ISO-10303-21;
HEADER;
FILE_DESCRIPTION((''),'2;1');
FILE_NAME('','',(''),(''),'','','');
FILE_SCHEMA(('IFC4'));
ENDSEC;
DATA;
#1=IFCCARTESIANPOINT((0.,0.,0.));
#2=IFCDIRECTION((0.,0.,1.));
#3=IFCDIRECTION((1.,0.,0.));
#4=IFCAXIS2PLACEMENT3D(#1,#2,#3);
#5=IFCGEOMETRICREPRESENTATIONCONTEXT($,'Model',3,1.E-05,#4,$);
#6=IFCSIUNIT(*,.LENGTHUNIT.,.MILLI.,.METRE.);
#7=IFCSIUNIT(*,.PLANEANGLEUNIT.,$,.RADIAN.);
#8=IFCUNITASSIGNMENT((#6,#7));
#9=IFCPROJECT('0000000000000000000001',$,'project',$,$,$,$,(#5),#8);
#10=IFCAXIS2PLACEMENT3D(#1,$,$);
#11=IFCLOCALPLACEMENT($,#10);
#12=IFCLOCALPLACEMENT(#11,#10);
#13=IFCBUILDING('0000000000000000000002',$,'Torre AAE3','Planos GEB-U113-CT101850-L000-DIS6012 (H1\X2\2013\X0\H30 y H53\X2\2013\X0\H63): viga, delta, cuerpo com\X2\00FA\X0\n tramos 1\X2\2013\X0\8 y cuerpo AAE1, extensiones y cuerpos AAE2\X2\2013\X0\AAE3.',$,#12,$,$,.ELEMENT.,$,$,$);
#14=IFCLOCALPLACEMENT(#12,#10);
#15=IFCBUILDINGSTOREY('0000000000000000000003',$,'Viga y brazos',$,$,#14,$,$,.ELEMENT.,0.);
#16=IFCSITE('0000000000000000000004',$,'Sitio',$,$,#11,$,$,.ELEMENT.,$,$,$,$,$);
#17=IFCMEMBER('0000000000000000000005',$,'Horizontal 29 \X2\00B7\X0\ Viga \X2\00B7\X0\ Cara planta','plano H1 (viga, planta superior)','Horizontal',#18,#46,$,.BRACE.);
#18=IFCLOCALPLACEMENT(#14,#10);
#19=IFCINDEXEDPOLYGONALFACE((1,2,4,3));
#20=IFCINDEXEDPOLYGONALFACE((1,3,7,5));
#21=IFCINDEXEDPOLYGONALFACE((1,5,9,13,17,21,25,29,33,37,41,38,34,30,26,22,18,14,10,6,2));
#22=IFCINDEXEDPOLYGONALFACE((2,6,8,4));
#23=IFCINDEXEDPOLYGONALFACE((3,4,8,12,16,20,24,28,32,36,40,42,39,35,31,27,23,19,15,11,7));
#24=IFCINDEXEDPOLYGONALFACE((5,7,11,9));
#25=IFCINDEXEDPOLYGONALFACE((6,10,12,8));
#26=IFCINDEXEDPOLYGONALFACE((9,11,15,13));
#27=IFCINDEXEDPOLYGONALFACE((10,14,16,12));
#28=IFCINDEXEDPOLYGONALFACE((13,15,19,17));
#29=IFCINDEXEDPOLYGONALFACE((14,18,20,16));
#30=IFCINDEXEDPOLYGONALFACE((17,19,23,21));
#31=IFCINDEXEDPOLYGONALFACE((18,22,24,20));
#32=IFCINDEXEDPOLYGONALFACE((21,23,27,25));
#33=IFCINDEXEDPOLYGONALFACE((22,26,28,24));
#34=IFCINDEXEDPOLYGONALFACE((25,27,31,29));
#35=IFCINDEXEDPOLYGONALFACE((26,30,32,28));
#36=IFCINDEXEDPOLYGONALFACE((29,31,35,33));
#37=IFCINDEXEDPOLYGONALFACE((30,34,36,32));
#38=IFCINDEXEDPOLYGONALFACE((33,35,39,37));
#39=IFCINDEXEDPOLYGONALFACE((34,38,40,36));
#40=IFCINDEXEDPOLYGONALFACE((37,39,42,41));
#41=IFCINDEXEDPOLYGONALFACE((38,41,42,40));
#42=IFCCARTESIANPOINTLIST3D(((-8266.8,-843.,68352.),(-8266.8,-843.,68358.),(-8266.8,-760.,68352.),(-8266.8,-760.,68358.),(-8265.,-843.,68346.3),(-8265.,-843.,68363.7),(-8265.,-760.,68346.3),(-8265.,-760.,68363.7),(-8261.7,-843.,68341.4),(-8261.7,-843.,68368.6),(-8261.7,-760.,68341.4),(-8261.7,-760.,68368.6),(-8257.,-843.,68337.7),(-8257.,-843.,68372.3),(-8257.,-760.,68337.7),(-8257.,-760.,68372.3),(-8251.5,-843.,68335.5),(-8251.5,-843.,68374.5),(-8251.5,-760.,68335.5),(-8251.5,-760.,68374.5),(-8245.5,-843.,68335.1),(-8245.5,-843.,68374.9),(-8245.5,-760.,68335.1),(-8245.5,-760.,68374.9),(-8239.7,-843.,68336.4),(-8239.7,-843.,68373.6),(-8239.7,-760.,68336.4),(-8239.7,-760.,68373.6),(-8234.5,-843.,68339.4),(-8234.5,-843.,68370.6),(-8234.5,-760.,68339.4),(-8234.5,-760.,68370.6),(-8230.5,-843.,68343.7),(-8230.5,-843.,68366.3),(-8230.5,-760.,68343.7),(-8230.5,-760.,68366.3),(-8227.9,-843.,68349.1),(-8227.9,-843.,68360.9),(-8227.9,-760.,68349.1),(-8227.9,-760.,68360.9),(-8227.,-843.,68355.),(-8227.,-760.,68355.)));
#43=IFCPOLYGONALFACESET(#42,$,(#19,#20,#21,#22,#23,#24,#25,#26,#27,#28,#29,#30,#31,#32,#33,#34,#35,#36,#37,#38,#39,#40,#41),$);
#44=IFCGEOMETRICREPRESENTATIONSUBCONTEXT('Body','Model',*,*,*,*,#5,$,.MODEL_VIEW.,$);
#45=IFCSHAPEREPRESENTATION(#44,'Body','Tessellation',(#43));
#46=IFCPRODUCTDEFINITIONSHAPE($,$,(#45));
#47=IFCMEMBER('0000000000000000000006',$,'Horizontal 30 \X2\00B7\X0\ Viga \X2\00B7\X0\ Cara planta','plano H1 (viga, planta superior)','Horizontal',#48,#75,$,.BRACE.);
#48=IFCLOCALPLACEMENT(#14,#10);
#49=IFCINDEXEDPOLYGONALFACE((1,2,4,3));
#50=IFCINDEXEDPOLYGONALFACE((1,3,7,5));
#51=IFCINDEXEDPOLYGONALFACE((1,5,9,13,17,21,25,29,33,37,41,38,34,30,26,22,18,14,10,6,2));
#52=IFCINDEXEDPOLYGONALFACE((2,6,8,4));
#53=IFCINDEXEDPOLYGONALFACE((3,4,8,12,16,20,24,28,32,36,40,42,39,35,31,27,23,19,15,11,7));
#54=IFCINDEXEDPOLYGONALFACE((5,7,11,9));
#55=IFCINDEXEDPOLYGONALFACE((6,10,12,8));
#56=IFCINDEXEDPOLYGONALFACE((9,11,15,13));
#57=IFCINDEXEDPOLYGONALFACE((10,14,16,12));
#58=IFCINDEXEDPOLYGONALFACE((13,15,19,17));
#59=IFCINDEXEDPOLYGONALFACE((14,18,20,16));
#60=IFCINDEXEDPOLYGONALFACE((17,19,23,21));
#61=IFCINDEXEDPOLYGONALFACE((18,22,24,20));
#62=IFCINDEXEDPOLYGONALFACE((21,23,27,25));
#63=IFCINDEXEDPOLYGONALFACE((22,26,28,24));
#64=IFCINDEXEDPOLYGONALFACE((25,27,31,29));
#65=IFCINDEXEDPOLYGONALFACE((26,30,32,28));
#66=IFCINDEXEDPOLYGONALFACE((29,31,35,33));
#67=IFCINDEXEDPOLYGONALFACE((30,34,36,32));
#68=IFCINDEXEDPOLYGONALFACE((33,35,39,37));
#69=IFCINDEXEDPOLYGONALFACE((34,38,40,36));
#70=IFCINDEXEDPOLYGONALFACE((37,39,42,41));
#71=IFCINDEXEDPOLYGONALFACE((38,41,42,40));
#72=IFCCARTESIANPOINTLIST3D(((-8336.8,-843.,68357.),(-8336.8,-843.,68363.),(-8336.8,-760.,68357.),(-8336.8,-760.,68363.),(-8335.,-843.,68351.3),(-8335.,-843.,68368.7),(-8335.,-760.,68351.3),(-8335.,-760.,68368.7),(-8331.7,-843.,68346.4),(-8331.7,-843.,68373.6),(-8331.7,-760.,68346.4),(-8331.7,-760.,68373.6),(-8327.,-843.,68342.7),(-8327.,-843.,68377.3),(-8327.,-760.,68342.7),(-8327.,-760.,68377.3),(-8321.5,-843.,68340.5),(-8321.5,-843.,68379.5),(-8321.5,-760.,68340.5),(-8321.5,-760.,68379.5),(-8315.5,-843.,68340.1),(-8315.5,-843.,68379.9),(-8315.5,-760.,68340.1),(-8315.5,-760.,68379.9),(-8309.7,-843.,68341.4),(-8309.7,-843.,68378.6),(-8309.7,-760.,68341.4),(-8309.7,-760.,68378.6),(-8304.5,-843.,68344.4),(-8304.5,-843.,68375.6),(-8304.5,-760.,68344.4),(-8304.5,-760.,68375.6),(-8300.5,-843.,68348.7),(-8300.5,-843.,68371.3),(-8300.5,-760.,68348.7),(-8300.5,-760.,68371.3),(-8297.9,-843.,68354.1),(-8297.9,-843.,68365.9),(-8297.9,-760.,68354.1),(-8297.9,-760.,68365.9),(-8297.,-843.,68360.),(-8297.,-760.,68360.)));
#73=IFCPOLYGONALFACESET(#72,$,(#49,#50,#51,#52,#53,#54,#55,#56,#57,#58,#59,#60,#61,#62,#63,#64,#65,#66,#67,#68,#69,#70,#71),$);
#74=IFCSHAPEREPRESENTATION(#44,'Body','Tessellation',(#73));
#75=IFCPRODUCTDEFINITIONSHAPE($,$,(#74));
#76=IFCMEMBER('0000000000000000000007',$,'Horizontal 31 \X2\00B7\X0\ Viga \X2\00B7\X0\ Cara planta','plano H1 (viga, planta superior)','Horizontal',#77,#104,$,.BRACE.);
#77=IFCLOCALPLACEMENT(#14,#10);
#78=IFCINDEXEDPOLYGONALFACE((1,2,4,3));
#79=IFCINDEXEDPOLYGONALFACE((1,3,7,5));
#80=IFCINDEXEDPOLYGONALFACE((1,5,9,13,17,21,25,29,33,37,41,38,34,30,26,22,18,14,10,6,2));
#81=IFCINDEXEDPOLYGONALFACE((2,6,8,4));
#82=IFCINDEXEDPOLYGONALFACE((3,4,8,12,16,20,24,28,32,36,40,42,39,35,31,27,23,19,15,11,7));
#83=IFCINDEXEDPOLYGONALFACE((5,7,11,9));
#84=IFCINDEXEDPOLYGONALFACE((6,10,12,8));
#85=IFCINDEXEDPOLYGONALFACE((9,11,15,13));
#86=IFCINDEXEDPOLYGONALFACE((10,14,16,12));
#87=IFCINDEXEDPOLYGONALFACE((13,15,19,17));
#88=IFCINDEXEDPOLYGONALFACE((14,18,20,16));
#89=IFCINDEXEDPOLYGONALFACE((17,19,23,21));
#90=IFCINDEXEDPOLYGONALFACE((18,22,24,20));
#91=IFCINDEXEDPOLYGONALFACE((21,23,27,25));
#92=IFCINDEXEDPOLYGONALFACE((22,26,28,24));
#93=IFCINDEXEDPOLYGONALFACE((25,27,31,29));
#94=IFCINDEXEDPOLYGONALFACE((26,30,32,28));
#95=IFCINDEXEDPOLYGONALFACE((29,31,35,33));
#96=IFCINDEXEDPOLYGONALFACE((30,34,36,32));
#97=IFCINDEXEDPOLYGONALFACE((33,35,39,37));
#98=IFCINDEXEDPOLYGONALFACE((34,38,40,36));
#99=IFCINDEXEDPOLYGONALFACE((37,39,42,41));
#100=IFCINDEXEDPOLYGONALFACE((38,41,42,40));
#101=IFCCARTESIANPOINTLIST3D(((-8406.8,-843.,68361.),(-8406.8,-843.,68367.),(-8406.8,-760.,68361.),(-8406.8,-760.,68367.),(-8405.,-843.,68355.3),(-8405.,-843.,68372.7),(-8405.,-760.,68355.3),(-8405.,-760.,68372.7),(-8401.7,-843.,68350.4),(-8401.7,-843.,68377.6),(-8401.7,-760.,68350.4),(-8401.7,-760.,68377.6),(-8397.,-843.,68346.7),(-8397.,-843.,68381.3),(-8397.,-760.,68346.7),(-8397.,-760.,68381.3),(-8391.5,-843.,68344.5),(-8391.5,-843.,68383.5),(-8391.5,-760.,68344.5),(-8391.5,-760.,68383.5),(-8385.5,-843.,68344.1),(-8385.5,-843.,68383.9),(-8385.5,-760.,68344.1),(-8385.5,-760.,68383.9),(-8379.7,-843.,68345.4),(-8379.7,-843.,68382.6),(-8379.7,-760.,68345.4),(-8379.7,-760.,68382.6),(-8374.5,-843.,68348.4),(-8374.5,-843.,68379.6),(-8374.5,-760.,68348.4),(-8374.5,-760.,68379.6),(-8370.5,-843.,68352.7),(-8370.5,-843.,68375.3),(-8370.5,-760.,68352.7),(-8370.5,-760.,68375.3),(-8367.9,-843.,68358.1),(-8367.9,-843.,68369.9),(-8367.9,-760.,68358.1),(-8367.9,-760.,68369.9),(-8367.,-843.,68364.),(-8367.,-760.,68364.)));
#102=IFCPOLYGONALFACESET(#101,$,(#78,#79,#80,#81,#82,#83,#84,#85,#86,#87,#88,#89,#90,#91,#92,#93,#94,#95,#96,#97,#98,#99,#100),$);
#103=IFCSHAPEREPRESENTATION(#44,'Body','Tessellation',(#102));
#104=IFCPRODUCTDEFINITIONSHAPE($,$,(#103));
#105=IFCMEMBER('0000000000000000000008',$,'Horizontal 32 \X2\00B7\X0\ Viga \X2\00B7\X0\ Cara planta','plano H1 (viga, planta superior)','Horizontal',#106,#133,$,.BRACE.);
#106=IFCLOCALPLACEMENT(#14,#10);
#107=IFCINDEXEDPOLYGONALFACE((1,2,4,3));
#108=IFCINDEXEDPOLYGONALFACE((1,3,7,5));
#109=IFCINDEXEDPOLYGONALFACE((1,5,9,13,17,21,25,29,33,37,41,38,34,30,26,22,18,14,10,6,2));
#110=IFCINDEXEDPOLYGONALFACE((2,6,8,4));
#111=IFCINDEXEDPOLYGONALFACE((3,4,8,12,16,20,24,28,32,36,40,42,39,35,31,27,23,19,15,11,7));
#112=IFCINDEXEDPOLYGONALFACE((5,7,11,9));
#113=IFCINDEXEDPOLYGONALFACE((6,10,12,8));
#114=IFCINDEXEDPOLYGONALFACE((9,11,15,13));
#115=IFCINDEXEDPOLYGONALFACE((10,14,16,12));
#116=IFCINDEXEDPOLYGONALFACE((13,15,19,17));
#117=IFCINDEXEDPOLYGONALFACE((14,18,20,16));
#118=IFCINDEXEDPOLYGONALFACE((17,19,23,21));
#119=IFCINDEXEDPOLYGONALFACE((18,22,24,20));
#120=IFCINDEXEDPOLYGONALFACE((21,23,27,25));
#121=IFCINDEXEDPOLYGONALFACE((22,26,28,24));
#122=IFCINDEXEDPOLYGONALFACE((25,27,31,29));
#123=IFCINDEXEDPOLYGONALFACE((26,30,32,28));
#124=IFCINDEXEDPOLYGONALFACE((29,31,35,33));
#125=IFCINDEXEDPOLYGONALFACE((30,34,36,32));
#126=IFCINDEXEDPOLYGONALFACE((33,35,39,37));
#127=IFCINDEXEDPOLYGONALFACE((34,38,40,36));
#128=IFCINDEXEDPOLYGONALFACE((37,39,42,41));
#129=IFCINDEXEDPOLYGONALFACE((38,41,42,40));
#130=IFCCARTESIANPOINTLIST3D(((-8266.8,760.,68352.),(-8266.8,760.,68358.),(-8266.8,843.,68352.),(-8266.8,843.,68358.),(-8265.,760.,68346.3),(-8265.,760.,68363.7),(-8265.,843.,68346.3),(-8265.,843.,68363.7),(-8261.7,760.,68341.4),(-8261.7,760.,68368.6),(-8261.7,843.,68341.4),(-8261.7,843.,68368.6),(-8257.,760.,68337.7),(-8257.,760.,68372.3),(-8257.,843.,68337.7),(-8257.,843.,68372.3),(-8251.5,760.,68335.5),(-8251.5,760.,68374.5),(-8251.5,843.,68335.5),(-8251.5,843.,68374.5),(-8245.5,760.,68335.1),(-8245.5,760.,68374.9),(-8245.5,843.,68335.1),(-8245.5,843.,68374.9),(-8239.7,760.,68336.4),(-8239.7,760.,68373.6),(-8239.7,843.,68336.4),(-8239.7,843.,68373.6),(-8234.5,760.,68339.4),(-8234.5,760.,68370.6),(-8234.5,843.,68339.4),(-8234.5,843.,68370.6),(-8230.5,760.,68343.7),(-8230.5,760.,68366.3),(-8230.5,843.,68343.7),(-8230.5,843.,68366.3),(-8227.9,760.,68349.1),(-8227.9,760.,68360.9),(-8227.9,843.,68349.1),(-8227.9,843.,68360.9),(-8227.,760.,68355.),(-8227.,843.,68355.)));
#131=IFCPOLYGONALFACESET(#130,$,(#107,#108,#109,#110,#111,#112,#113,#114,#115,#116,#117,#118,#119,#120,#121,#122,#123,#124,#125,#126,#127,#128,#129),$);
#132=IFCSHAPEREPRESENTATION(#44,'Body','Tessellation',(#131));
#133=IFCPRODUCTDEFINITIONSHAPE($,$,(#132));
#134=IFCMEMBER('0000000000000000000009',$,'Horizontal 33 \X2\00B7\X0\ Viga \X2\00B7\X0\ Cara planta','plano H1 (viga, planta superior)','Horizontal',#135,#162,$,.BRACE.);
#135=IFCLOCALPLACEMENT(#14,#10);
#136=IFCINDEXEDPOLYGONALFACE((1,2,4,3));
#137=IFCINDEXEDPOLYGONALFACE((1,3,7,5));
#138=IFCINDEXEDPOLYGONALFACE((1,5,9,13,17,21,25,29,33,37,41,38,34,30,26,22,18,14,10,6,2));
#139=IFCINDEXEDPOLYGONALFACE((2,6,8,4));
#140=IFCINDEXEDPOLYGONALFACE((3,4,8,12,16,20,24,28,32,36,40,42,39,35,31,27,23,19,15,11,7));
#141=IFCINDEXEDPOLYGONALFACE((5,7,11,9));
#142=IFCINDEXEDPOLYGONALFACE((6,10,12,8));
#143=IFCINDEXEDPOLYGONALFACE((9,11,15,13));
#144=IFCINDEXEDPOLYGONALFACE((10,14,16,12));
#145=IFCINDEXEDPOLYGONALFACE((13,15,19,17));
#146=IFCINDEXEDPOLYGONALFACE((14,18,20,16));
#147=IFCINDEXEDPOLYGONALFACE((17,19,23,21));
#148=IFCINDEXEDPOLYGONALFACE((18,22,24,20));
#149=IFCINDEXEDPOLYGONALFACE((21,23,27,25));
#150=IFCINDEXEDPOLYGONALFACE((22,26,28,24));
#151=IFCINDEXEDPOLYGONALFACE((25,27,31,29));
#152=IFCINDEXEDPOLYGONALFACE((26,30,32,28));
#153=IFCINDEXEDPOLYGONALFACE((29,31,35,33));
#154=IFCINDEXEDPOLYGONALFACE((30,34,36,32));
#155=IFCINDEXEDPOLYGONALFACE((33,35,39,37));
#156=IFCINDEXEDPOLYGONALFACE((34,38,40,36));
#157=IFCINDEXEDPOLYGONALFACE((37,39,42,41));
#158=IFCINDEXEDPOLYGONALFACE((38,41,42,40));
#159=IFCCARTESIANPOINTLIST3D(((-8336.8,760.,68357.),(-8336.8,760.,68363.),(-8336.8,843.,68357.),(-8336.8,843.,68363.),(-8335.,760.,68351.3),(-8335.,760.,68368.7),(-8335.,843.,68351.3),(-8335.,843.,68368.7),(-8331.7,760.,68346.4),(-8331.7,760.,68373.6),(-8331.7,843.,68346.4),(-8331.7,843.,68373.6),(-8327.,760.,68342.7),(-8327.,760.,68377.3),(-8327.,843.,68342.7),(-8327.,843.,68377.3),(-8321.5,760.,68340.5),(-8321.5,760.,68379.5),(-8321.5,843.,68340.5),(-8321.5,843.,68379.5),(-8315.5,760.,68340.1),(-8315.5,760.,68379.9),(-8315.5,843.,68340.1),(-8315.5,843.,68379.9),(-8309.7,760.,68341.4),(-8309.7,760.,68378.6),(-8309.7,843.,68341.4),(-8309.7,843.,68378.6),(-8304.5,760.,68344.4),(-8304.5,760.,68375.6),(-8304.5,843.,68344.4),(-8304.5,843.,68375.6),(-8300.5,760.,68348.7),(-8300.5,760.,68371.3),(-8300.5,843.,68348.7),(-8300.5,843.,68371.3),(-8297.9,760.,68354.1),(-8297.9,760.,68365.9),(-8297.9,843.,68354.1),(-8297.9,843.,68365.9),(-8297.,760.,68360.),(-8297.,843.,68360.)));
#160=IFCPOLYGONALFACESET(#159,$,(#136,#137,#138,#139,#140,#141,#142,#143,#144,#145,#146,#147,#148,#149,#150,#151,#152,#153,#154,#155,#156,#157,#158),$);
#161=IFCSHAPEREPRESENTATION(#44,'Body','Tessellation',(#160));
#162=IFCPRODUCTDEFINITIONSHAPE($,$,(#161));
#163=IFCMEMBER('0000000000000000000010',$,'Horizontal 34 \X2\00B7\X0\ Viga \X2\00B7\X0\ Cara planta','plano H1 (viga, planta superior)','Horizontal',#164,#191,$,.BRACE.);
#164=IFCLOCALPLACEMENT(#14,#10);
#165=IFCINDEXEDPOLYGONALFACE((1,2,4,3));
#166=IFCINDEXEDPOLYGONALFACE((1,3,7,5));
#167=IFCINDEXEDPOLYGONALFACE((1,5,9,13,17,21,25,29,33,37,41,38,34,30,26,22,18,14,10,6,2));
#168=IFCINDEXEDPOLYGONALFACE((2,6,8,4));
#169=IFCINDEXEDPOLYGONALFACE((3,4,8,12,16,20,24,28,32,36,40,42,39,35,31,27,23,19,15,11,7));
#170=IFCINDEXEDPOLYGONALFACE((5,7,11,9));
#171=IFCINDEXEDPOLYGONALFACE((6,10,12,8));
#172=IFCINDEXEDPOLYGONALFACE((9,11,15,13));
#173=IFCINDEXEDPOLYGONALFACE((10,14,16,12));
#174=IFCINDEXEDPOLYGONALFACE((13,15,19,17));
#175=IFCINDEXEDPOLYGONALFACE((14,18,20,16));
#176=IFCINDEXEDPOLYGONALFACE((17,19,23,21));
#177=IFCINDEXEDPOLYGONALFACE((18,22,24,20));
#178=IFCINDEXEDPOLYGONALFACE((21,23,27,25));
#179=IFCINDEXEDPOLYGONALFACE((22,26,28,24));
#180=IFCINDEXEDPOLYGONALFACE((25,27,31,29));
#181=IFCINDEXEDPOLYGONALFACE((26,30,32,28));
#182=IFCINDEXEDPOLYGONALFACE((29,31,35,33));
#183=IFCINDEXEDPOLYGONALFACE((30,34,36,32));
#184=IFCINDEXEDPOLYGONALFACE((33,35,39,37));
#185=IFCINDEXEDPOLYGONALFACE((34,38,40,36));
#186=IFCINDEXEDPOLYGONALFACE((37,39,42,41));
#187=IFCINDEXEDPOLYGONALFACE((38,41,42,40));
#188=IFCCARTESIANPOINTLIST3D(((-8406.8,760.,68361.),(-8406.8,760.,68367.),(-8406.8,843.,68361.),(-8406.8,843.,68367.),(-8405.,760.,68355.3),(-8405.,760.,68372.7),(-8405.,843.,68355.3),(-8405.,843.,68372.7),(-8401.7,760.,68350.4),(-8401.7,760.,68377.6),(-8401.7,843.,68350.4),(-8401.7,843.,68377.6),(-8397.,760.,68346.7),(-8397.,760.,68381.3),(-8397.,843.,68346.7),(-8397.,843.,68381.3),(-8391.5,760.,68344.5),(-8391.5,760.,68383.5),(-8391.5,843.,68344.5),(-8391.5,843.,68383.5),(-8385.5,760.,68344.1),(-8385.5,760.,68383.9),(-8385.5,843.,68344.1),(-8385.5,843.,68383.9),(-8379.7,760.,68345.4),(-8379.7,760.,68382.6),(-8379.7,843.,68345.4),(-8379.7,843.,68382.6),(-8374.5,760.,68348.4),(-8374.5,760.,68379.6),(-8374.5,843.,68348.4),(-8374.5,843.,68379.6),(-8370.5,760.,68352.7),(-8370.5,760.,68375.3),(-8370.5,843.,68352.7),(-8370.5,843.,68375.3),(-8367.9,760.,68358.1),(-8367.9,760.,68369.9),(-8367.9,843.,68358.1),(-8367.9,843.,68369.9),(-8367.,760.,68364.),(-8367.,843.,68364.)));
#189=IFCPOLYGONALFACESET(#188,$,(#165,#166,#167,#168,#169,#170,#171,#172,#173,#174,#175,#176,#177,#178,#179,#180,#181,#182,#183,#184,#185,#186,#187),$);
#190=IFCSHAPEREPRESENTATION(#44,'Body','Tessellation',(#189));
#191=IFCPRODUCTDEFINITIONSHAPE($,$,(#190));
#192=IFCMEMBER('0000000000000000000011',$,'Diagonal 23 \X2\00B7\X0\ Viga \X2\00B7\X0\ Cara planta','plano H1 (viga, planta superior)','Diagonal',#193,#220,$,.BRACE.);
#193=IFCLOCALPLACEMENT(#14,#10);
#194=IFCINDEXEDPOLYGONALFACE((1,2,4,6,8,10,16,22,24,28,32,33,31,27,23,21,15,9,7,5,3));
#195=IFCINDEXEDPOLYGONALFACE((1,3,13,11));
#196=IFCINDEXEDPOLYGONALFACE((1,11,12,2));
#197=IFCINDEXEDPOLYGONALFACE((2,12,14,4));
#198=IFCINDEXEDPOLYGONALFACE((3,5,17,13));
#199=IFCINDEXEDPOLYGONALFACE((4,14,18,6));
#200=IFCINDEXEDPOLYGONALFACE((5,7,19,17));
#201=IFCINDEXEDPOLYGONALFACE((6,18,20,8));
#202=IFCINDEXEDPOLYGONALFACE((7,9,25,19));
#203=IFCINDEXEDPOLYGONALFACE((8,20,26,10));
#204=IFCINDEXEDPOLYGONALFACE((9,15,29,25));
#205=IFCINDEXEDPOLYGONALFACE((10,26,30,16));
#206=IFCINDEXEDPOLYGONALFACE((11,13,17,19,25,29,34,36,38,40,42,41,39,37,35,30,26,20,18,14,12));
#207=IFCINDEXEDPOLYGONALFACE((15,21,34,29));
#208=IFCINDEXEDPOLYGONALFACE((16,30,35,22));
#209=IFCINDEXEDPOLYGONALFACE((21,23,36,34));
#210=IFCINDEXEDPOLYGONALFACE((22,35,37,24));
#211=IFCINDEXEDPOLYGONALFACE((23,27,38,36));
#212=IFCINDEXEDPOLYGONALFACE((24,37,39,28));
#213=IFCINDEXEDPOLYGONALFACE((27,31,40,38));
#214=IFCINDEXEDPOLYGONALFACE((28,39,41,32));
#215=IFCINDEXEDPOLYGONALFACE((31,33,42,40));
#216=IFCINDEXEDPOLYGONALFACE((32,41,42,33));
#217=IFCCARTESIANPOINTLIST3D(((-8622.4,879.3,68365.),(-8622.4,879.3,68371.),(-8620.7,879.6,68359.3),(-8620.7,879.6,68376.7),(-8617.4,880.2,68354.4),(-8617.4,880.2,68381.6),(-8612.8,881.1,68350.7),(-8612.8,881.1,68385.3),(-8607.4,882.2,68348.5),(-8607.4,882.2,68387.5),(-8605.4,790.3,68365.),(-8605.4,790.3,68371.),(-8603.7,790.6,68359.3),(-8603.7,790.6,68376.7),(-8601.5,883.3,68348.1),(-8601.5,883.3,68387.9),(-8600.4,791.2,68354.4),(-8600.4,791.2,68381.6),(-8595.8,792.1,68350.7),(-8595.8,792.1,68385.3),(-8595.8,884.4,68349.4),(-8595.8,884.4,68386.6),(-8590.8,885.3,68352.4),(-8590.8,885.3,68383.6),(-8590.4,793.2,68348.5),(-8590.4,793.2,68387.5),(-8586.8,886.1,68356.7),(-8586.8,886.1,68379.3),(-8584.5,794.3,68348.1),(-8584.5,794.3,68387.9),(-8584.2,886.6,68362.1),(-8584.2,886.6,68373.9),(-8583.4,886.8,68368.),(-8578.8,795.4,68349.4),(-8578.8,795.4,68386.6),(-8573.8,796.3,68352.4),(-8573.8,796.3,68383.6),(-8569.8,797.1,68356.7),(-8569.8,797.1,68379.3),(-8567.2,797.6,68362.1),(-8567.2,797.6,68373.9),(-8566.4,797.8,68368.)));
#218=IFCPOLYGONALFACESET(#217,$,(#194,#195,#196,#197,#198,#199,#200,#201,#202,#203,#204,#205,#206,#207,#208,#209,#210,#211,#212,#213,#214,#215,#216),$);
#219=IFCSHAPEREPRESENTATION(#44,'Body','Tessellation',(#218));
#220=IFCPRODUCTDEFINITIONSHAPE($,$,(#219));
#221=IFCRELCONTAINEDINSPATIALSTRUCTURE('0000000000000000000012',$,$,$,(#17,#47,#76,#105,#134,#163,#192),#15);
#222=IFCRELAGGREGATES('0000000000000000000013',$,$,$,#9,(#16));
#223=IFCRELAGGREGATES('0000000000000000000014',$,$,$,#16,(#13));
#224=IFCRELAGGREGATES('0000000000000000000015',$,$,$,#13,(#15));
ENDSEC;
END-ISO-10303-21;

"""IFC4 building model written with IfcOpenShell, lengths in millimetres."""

from ifc_helpers import new_model, si_unit, frame, origin, origin_with_axes, place, context, subcontext, project, spatial, circle, extrude, element, save


model = new_model("IFC4")

# Units and contexts
model_context = context("Model", 3, precision=1e-05, world=origin_with_axes())
body_context = subcontext(model_context, "Body", "Model", "MODEL_VIEW")
ifc_project = project(units=[si_unit("LENGTHUNIT", "METRE", prefix="MILLI"), si_unit("PLANEANGLEUNIT", "RADIAN")], contexts=[model_context])

# Site, building, storey
site_placement = place(None, origin())
site = spatial("IfcSite", under=ifc_project, at=site_placement, Name="Sitio", CompositionType="ELEMENT")
building_placement = place(site_placement, origin())
building = spatial("IfcBuilding", under=site, at=building_placement, Name="Torre AAE3", Description="Planos GEB-U113-CT101850-L000-DIS6012 (H1–H30 y H53–H63): viga, delta, cuerpo común tramos 1–8 y cuerpo AAE1, extensiones y cuerpos AAE2–AAE3.", CompositionType="ELEMENT")
storey_placement = place(building_placement, origin())
storey = spatial("IfcBuildingStorey", under=building, at=storey_placement, Name="Viga y brazos", CompositionType="ELEMENT", Elevation=0.0)

# Members
for number, where, z_axis, x_axis, name in (
    (1, (-8247.0, -843.0, 68355.0), (0.0, 1.0, 0.0), (1.0, 0.0, 0.0), "Horizontal 29 · Viga · Cara planta"),
    (2, (-8317.0, -843.0, 68360.0), (0.0, 1.0, 0.0), (1.0, 0.0, 0.0), "Horizontal 30 · Viga · Cara planta"),
    (3, (-8387.0, -843.0, 68364.0), (0.0, 1.0, 0.0), (1.0, 0.0, 0.0), "Horizontal 31 · Viga · Cara planta"),
    (4, (-8247.0, 843.0, 68355.0), (0.0, -1.0, 0.0), (1.0, 0.0, 0.0), "Horizontal 32 · Viga · Cara planta"),
    (5, (-8317.0, 843.0, 68360.0), (0.0, -1.0, 0.0), (1.0, 0.0, 0.0), "Horizontal 33 · Viga · Cara planta"),
    (6, (-8387.0, 843.0, 68364.0), (0.0, -1.0, 0.0), (1.0, 0.0, 0.0), "Horizontal 34 · Viga · Cara planta"),
):
    element("IfcMember", number, at=place(storey_placement, frame(where, z_axis=z_axis, x_axis=x_axis)), inside=storey, Name=name, Description="plano H1 (viga, planta superior)", ObjectType="Horizontal", PredefinedType="BRACE", context=body_context, shape_type="SweptSolid", body=[
        extrude(circle(Radius=20.0), None, (0.0, 0.0, 1.0), 83.0),
    ])
member_1_placement = place(storey_placement, frame((-8586.0, 794.0, 68368.0), z_axis=(-0.187619, 0.982242, 0.0), x_axis=(0.982242, 0.187619, 0.0)))
element("IfcMember", 7, at=member_1_placement, inside=storey, Name="Diagonal 23 · Viga · Cara planta", Description="plano H1 (viga, planta superior)", ObjectType="Diagonal", PredefinedType="BRACE", context=body_context, shape_type="SweptSolid", body=[
    extrude(circle(Radius=20.0), None, (0.0, 0.0, 1.0), 90.6),
])

save(model, "model.ifc")
